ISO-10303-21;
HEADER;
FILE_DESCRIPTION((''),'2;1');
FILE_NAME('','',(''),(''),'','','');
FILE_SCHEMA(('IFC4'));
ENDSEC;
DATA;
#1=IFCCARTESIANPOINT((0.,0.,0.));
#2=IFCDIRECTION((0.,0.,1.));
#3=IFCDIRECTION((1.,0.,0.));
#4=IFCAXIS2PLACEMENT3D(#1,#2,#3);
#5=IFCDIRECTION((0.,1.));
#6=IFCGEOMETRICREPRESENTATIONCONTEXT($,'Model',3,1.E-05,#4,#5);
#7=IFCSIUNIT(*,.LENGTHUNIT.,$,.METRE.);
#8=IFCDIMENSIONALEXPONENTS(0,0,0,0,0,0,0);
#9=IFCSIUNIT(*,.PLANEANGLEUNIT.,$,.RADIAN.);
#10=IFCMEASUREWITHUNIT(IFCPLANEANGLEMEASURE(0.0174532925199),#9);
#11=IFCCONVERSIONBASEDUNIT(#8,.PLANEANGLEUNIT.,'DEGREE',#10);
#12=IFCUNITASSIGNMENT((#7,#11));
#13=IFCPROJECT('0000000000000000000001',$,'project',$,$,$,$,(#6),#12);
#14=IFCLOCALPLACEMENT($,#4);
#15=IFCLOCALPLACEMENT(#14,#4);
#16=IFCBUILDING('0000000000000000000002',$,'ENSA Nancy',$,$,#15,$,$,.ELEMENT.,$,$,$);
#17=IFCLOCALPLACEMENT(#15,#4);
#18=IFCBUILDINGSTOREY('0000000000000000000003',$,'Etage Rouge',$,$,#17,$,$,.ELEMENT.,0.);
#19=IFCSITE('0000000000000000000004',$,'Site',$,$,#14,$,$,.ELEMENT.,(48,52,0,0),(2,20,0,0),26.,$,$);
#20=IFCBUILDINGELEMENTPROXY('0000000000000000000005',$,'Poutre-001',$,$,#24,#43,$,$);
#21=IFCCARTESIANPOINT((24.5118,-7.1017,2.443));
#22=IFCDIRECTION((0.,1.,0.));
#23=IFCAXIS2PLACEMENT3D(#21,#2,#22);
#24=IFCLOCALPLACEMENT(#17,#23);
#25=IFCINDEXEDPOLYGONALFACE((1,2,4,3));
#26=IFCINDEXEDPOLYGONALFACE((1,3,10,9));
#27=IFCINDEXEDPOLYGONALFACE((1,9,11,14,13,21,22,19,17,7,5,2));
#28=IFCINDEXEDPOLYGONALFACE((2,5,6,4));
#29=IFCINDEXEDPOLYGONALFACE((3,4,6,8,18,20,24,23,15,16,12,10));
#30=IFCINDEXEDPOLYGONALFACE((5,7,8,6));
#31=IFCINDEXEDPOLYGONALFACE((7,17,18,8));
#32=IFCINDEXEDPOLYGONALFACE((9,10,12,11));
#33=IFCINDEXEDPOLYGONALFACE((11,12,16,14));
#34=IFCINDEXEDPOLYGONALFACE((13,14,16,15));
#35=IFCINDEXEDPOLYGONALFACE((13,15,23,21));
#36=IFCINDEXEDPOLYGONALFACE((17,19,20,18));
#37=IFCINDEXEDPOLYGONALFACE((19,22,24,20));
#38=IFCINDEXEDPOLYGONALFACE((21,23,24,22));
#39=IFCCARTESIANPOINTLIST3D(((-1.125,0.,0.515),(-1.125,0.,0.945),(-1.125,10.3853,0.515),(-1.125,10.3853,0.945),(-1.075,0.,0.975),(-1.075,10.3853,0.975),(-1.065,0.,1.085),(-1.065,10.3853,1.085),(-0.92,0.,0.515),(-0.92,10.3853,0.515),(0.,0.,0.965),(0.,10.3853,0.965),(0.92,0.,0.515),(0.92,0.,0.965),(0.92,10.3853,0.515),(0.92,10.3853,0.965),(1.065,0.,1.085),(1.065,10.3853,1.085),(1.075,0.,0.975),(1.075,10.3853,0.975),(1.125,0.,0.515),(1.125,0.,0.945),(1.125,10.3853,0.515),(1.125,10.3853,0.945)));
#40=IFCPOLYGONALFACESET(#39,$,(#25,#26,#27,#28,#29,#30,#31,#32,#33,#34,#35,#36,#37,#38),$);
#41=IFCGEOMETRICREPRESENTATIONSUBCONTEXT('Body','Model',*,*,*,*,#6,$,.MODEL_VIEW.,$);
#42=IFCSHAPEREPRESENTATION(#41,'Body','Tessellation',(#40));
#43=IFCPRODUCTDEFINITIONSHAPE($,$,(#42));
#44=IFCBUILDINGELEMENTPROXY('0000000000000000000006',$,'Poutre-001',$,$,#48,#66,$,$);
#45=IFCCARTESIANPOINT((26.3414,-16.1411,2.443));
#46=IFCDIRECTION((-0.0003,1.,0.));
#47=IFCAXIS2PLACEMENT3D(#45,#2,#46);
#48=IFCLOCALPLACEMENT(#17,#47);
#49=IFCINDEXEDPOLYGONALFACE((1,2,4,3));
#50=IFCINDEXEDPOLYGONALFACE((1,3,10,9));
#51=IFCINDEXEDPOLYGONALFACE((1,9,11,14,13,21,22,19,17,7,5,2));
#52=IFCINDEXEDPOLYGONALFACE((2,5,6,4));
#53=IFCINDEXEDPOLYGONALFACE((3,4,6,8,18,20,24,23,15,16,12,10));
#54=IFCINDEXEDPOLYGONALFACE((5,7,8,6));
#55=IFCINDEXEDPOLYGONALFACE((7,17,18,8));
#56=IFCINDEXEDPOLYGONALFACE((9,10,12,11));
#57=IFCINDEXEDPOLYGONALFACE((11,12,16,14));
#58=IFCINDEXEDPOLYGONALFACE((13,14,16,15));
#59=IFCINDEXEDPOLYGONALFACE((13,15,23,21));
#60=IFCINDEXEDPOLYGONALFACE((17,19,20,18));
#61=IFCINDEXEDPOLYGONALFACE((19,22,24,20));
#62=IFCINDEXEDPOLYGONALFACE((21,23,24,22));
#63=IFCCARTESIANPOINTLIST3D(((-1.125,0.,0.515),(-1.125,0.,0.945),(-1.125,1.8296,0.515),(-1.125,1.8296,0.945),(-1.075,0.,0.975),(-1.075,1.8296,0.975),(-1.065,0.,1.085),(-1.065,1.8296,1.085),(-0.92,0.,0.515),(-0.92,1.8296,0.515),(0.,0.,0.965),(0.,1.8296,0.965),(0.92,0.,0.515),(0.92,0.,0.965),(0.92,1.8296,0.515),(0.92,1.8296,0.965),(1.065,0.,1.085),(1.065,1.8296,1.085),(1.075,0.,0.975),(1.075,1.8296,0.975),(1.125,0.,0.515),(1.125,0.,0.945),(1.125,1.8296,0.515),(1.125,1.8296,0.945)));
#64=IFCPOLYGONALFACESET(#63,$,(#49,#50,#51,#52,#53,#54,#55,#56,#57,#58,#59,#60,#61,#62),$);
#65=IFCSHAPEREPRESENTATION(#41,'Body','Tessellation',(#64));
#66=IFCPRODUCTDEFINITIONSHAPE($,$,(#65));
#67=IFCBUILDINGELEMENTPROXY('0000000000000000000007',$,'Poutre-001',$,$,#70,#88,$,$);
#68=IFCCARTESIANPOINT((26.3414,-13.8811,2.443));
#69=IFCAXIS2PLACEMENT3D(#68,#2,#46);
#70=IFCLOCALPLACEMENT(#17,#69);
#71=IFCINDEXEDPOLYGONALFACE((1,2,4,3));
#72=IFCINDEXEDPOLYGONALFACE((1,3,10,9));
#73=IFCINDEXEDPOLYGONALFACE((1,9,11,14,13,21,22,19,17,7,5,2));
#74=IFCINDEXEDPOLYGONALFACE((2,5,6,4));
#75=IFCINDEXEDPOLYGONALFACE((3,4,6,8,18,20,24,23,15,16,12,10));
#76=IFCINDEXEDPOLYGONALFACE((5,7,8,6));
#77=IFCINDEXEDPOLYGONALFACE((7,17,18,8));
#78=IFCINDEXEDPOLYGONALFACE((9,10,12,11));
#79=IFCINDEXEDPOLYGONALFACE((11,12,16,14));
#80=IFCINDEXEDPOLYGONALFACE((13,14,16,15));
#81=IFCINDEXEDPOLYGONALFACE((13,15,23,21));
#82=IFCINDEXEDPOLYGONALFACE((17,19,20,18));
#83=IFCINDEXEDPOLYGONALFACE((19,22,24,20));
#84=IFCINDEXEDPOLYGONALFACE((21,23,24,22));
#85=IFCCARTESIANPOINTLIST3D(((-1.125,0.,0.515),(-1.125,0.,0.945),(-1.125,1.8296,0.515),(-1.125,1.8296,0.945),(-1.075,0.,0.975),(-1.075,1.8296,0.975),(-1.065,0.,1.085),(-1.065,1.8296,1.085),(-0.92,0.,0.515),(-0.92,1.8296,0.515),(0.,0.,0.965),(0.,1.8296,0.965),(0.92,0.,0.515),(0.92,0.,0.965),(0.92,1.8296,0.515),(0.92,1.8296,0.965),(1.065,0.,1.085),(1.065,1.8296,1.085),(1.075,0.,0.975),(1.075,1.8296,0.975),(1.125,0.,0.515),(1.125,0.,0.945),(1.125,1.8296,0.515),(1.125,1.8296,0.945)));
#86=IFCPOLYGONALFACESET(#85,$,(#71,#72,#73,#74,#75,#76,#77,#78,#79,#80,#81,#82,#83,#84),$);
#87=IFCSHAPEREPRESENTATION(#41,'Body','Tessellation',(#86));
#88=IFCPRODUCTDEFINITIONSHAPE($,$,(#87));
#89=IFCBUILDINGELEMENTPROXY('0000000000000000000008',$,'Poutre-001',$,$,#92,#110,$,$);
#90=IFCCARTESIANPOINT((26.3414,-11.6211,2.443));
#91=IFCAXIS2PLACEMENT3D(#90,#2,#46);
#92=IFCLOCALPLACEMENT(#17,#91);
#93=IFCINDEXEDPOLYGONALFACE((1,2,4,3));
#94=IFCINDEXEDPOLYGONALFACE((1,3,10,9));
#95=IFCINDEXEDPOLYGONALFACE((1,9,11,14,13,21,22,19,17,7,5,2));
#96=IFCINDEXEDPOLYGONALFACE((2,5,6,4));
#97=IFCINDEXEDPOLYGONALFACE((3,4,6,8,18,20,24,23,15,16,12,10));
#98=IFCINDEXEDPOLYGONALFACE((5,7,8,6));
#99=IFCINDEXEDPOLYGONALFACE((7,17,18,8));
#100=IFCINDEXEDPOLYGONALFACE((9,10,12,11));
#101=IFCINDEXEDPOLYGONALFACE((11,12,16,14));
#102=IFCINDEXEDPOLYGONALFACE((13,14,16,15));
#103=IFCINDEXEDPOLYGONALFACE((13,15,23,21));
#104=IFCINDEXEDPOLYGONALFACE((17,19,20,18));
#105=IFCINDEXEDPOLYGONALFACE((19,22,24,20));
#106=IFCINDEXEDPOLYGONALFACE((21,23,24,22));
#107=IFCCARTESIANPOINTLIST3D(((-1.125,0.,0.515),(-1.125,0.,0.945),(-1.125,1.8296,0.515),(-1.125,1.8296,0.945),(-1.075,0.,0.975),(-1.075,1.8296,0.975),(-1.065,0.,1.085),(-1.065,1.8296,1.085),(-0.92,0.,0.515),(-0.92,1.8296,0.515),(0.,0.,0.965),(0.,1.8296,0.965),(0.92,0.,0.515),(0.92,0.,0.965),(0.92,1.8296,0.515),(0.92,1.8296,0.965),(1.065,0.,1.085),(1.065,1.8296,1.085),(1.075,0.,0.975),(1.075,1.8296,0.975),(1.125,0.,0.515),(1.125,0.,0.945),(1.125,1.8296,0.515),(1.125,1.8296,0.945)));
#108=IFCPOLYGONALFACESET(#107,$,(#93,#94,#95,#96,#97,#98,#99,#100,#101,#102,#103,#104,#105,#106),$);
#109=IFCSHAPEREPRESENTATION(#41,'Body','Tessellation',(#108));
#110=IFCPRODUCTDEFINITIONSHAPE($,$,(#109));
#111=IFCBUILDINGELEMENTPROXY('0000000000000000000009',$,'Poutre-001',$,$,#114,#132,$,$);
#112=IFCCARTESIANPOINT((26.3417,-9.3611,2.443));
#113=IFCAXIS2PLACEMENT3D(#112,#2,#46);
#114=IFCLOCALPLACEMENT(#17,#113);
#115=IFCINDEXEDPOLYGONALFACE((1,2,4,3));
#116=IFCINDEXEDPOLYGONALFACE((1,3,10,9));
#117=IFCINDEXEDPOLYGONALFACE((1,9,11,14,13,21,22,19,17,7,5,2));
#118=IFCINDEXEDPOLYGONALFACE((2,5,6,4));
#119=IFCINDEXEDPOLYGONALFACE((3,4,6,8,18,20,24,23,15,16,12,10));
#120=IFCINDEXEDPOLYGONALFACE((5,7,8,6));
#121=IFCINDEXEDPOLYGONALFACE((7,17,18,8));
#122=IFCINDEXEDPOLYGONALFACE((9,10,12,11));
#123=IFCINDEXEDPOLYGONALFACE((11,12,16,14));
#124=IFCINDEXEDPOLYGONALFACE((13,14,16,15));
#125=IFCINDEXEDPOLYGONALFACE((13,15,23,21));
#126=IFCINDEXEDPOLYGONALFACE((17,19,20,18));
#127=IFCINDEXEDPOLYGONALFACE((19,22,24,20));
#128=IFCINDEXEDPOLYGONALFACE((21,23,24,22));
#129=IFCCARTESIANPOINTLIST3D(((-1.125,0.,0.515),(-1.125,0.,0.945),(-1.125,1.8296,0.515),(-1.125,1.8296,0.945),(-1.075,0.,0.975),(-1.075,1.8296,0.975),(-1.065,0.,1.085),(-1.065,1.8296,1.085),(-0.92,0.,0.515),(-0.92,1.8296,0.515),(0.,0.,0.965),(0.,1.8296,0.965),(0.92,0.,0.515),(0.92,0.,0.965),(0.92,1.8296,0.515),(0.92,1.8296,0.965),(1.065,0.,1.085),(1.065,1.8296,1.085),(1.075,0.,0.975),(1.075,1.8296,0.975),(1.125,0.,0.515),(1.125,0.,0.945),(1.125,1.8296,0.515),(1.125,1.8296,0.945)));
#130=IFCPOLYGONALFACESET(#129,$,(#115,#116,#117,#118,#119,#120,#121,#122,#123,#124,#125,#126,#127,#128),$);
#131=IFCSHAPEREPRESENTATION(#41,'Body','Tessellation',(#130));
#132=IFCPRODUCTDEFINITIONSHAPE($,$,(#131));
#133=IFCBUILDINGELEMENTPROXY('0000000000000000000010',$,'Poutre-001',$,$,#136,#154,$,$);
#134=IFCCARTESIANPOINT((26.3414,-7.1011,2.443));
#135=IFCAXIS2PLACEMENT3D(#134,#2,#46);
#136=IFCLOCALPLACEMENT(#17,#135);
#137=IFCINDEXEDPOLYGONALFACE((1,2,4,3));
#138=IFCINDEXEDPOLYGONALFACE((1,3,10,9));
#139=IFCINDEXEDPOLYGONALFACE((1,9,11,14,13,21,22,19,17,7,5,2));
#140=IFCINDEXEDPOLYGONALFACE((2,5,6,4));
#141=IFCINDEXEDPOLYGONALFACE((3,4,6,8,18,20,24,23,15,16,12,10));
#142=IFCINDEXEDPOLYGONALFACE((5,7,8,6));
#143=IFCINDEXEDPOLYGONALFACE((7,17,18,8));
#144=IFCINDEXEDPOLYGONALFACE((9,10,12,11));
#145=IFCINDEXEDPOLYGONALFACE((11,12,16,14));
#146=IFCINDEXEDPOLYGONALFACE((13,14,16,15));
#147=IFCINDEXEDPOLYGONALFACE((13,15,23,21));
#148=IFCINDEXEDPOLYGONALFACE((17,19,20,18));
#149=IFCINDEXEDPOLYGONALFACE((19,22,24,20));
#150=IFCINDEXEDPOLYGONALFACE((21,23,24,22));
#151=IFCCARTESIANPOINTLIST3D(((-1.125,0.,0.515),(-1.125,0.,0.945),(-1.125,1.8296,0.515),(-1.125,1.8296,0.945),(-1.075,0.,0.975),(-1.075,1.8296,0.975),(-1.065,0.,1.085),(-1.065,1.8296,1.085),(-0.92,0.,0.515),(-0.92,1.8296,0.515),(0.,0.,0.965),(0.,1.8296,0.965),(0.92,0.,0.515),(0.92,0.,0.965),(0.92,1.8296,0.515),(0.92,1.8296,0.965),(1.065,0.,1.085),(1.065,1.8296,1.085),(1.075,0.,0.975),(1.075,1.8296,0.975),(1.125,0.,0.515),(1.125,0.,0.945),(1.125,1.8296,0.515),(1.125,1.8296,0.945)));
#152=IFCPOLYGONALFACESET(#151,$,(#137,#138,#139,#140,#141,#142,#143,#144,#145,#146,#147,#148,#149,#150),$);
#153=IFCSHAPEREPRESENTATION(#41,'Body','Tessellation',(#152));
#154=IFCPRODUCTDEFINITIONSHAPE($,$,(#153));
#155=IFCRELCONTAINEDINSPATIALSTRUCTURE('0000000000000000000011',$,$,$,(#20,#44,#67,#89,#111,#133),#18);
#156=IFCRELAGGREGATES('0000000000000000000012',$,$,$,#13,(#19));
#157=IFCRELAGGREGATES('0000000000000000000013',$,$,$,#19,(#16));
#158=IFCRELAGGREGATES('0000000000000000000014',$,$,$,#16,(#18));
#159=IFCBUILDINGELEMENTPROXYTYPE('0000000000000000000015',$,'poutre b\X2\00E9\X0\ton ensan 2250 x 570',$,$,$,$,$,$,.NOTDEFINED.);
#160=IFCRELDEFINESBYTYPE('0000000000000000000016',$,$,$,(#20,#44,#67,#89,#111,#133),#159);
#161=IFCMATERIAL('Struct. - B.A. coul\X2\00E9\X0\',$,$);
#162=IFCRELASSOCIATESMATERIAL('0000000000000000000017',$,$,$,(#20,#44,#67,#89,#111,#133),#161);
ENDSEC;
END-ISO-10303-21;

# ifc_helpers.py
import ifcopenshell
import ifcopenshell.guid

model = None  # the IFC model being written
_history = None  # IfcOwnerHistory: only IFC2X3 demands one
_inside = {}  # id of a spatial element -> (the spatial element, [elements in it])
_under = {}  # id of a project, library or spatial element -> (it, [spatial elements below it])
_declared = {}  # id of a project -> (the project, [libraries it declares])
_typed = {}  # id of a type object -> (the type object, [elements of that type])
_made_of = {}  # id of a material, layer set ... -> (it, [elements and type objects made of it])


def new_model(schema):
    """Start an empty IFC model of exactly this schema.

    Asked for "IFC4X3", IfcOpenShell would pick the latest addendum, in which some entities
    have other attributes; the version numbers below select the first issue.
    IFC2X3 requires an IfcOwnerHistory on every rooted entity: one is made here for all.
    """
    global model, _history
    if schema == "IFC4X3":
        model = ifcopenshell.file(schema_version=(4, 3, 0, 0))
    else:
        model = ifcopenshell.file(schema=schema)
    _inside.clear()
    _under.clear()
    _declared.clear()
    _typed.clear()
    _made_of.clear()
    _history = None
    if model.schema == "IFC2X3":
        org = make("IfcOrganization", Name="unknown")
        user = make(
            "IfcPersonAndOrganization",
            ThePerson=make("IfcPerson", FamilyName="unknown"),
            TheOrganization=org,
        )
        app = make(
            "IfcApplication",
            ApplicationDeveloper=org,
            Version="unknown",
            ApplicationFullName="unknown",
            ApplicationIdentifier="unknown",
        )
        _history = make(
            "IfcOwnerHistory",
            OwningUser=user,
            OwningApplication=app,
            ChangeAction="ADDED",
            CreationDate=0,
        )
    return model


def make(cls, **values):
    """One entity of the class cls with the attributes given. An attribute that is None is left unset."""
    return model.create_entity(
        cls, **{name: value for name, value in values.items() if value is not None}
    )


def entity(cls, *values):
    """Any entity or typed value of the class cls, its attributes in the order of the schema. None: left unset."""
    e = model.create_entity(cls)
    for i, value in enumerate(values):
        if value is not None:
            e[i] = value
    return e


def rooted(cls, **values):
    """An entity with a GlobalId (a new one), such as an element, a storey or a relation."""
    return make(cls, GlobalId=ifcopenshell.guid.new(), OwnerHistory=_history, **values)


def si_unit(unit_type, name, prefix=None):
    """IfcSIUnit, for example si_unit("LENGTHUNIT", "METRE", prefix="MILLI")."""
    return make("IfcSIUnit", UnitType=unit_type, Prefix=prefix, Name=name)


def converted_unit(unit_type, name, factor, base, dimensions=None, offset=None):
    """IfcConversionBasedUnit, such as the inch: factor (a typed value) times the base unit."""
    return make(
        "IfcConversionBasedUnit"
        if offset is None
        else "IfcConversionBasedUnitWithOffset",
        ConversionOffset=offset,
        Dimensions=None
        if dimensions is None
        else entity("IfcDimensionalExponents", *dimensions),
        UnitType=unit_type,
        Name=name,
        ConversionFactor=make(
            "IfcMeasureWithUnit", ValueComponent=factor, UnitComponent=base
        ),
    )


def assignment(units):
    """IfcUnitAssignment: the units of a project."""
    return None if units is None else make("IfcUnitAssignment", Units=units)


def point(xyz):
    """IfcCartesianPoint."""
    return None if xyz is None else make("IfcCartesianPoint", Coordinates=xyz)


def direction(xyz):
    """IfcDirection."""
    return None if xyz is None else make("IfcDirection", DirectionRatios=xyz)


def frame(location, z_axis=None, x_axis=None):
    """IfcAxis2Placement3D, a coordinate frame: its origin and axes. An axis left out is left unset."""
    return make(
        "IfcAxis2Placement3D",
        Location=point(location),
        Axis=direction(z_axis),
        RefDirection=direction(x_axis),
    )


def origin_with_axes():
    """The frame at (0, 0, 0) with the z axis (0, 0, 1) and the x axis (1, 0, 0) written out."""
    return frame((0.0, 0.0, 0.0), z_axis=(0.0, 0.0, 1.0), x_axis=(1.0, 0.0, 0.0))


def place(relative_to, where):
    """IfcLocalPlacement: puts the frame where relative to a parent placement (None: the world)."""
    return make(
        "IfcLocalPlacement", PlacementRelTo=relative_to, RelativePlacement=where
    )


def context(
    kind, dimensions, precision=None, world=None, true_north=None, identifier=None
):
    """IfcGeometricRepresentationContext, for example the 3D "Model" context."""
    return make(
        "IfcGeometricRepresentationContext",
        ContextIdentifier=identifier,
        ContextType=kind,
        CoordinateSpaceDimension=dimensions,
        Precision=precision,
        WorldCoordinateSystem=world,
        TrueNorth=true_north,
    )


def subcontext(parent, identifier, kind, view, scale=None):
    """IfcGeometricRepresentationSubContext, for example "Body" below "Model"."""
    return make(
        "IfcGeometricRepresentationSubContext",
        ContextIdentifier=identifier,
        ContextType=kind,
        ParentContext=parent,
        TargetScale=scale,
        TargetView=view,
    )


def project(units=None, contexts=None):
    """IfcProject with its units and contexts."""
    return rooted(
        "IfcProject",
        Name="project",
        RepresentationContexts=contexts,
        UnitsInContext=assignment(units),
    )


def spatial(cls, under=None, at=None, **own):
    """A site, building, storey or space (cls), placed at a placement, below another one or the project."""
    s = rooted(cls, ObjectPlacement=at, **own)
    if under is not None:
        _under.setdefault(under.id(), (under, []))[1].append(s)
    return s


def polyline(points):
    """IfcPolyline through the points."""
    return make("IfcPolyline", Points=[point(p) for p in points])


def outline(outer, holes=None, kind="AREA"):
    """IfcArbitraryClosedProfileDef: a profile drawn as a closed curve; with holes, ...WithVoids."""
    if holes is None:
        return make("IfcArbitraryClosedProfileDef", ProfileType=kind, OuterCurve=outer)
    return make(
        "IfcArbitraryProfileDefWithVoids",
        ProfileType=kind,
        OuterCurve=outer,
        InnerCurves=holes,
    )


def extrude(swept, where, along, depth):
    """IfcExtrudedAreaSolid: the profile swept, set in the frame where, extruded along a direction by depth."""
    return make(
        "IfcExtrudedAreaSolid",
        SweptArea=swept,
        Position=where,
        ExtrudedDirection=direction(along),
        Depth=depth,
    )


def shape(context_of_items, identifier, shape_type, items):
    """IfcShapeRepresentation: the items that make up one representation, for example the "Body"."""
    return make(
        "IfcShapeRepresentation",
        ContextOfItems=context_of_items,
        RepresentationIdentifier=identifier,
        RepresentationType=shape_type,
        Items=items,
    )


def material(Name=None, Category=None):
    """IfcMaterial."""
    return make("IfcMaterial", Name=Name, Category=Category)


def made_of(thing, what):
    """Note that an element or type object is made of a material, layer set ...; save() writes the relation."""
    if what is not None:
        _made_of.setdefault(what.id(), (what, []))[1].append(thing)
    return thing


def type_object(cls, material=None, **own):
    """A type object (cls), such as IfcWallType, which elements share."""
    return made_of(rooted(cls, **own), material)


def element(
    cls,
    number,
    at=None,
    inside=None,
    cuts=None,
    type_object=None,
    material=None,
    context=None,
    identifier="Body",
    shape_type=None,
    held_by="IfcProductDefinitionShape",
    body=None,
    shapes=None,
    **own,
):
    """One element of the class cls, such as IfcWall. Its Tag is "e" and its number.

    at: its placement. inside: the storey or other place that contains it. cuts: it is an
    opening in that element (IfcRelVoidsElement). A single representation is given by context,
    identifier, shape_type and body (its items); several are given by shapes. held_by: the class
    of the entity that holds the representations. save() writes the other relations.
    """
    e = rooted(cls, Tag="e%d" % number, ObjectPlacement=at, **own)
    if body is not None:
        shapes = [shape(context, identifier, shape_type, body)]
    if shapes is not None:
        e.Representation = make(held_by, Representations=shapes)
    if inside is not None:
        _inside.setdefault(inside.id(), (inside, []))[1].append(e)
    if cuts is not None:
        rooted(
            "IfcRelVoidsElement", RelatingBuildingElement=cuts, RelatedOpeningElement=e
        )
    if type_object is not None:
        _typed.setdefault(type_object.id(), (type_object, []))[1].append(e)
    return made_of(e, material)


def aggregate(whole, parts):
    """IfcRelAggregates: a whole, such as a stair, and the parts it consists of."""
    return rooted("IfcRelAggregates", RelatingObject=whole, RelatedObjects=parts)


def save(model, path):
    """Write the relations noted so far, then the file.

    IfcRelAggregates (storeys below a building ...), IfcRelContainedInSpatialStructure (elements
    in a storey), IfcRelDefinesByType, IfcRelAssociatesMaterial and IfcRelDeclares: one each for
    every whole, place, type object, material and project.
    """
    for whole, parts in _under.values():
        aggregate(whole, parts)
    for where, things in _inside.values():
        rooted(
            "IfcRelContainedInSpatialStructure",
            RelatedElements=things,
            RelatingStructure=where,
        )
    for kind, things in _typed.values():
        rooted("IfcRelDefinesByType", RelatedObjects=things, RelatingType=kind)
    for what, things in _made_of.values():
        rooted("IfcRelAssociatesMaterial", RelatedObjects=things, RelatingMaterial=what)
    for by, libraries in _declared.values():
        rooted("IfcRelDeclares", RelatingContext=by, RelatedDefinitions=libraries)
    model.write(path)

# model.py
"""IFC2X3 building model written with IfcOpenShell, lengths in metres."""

from ifc_helpers import new_model, entity, si_unit, converted_unit, direction, frame, origin_with_axes, place, context, subcontext, project, spatial, polyline, outline, extrude, material, type_object, element, save


model = new_model("IFC2X3")

# Units and contexts
model_context = context("Model", 3, precision=1e-05, world=origin_with_axes(), true_north=direction((0.0, 1.0)))
body_context = subcontext(model_context, "Body", "Model", "MODEL_VIEW")
ifc_project = project(units=[si_unit("LENGTHUNIT", "METRE"), converted_unit("PLANEANGLEUNIT", "DEGREE", entity("IfcPlaneAngleMeasure", 0.0174532925199), si_unit("PLANEANGLEUNIT", "RADIAN"), dimensions=[0, 0, 0, 0, 0, 0, 0])], contexts=[model_context])

# Site, building, storey
site_placement = place(None, origin_with_axes())
site = spatial("IfcSite", under=ifc_project, at=site_placement, Name="Site", CompositionType="ELEMENT", RefLatitude=(48, 52, 0, 0), RefLongitude=(2, 20, 0, 0), RefElevation=26.0)
building_placement = place(site_placement, origin_with_axes())
building = spatial("IfcBuilding", under=site, at=building_placement, Name="ENSA Nancy", CompositionType="ELEMENT")
storey_placement = place(building_placement, origin_with_axes())
storey = spatial("IfcBuildingStorey", under=building, at=storey_placement, Name="Etage Rouge", CompositionType="ELEMENT", Elevation=0.0)

# Building element proxies
ifc_material_1 = material(Name="Struct. - B.A. coulé")
building_element_proxy_type_1 = type_object("IfcBuildingElementProxyType", Name="poutre béton ensan 2250 x 570", PredefinedType="NOTDEFINED")
for number, where, z_axis, x_axis, name in (
    (1, (24.5118, -7.1017, 2.443), (0.0, 0.0, 1.0), (0.0, 1.0, 0.0), "Poutre-001"),
):
    element("IfcBuildingElementProxy", number, at=place(storey_placement, frame(where, z_axis=z_axis, x_axis=x_axis)), inside=storey, type_object=building_element_proxy_type_1, material=ifc_material_1, Name=name, context=body_context, shape_type="SweptSolid", body=[
        extrude(outline(polyline([(-1.065, 1.085), (-1.075, 0.975), (-1.125, 0.945), (-1.125, 0.515), (-0.92, 0.515), (0.0, 0.965), (0.92, 0.965), (0.92, 0.515), (1.125, 0.515), (1.125, 0.945), (1.075, 0.975), (1.065, 1.085), (-1.065, 1.085)])), frame((0.0, 10.3853, 0.0), z_axis=(0.0, -1.0, 0.0), x_axis=(1.0, 0.0, 0.0)), (0.0, 0.0, 1.0), 10.3853),
    ])
for number, where, z_axis, x_axis, name in (
    (2, (26.3414, -16.1411, 2.443), (0.0, 0.0, 1.0), (-0.0003, 1.0, 0.0), "Poutre-001"),
    (3, (26.3414, -13.8811, 2.443), (0.0, 0.0, 1.0), (-0.0003, 1.0, 0.0), "Poutre-001"),
    (4, (26.3414, -11.6211, 2.443), (0.0, 0.0, 1.0), (-0.0003, 1.0, 0.0), "Poutre-001"),
    (5, (26.3417, -9.3611, 2.443), (0.0, 0.0, 1.0), (-0.0003, 1.0, 0.0), "Poutre-001"),
    (6, (26.3414, -7.1011, 2.443), (0.0, 0.0, 1.0), (-0.0003, 1.0, 0.0), "Poutre-001"),
):
    element("IfcBuildingElementProxy", number, at=place(storey_placement, frame(where, z_axis=z_axis, x_axis=x_axis)), inside=storey, type_object=building_element_proxy_type_1, material=ifc_material_1, Name=name, context=body_context, shape_type="SweptSolid", body=[
        extrude(outline(polyline([(-1.065, 1.085), (-1.075, 0.975), (-1.125, 0.945), (-1.125, 0.515), (-0.92, 0.515), (0.0, 0.965), (0.92, 0.965), (0.92, 0.515), (1.125, 0.515), (1.125, 0.945), (1.075, 0.975), (1.065, 1.085), (-1.065, 1.085)])), frame((0.0, 1.8296, 0.0), z_axis=(0.0, -1.0, 0.0), x_axis=(1.0, 0.0, 0.0)), (0.0, 0.0, 1.0), 1.8296),
    ])

save(model, "model.ifc")
